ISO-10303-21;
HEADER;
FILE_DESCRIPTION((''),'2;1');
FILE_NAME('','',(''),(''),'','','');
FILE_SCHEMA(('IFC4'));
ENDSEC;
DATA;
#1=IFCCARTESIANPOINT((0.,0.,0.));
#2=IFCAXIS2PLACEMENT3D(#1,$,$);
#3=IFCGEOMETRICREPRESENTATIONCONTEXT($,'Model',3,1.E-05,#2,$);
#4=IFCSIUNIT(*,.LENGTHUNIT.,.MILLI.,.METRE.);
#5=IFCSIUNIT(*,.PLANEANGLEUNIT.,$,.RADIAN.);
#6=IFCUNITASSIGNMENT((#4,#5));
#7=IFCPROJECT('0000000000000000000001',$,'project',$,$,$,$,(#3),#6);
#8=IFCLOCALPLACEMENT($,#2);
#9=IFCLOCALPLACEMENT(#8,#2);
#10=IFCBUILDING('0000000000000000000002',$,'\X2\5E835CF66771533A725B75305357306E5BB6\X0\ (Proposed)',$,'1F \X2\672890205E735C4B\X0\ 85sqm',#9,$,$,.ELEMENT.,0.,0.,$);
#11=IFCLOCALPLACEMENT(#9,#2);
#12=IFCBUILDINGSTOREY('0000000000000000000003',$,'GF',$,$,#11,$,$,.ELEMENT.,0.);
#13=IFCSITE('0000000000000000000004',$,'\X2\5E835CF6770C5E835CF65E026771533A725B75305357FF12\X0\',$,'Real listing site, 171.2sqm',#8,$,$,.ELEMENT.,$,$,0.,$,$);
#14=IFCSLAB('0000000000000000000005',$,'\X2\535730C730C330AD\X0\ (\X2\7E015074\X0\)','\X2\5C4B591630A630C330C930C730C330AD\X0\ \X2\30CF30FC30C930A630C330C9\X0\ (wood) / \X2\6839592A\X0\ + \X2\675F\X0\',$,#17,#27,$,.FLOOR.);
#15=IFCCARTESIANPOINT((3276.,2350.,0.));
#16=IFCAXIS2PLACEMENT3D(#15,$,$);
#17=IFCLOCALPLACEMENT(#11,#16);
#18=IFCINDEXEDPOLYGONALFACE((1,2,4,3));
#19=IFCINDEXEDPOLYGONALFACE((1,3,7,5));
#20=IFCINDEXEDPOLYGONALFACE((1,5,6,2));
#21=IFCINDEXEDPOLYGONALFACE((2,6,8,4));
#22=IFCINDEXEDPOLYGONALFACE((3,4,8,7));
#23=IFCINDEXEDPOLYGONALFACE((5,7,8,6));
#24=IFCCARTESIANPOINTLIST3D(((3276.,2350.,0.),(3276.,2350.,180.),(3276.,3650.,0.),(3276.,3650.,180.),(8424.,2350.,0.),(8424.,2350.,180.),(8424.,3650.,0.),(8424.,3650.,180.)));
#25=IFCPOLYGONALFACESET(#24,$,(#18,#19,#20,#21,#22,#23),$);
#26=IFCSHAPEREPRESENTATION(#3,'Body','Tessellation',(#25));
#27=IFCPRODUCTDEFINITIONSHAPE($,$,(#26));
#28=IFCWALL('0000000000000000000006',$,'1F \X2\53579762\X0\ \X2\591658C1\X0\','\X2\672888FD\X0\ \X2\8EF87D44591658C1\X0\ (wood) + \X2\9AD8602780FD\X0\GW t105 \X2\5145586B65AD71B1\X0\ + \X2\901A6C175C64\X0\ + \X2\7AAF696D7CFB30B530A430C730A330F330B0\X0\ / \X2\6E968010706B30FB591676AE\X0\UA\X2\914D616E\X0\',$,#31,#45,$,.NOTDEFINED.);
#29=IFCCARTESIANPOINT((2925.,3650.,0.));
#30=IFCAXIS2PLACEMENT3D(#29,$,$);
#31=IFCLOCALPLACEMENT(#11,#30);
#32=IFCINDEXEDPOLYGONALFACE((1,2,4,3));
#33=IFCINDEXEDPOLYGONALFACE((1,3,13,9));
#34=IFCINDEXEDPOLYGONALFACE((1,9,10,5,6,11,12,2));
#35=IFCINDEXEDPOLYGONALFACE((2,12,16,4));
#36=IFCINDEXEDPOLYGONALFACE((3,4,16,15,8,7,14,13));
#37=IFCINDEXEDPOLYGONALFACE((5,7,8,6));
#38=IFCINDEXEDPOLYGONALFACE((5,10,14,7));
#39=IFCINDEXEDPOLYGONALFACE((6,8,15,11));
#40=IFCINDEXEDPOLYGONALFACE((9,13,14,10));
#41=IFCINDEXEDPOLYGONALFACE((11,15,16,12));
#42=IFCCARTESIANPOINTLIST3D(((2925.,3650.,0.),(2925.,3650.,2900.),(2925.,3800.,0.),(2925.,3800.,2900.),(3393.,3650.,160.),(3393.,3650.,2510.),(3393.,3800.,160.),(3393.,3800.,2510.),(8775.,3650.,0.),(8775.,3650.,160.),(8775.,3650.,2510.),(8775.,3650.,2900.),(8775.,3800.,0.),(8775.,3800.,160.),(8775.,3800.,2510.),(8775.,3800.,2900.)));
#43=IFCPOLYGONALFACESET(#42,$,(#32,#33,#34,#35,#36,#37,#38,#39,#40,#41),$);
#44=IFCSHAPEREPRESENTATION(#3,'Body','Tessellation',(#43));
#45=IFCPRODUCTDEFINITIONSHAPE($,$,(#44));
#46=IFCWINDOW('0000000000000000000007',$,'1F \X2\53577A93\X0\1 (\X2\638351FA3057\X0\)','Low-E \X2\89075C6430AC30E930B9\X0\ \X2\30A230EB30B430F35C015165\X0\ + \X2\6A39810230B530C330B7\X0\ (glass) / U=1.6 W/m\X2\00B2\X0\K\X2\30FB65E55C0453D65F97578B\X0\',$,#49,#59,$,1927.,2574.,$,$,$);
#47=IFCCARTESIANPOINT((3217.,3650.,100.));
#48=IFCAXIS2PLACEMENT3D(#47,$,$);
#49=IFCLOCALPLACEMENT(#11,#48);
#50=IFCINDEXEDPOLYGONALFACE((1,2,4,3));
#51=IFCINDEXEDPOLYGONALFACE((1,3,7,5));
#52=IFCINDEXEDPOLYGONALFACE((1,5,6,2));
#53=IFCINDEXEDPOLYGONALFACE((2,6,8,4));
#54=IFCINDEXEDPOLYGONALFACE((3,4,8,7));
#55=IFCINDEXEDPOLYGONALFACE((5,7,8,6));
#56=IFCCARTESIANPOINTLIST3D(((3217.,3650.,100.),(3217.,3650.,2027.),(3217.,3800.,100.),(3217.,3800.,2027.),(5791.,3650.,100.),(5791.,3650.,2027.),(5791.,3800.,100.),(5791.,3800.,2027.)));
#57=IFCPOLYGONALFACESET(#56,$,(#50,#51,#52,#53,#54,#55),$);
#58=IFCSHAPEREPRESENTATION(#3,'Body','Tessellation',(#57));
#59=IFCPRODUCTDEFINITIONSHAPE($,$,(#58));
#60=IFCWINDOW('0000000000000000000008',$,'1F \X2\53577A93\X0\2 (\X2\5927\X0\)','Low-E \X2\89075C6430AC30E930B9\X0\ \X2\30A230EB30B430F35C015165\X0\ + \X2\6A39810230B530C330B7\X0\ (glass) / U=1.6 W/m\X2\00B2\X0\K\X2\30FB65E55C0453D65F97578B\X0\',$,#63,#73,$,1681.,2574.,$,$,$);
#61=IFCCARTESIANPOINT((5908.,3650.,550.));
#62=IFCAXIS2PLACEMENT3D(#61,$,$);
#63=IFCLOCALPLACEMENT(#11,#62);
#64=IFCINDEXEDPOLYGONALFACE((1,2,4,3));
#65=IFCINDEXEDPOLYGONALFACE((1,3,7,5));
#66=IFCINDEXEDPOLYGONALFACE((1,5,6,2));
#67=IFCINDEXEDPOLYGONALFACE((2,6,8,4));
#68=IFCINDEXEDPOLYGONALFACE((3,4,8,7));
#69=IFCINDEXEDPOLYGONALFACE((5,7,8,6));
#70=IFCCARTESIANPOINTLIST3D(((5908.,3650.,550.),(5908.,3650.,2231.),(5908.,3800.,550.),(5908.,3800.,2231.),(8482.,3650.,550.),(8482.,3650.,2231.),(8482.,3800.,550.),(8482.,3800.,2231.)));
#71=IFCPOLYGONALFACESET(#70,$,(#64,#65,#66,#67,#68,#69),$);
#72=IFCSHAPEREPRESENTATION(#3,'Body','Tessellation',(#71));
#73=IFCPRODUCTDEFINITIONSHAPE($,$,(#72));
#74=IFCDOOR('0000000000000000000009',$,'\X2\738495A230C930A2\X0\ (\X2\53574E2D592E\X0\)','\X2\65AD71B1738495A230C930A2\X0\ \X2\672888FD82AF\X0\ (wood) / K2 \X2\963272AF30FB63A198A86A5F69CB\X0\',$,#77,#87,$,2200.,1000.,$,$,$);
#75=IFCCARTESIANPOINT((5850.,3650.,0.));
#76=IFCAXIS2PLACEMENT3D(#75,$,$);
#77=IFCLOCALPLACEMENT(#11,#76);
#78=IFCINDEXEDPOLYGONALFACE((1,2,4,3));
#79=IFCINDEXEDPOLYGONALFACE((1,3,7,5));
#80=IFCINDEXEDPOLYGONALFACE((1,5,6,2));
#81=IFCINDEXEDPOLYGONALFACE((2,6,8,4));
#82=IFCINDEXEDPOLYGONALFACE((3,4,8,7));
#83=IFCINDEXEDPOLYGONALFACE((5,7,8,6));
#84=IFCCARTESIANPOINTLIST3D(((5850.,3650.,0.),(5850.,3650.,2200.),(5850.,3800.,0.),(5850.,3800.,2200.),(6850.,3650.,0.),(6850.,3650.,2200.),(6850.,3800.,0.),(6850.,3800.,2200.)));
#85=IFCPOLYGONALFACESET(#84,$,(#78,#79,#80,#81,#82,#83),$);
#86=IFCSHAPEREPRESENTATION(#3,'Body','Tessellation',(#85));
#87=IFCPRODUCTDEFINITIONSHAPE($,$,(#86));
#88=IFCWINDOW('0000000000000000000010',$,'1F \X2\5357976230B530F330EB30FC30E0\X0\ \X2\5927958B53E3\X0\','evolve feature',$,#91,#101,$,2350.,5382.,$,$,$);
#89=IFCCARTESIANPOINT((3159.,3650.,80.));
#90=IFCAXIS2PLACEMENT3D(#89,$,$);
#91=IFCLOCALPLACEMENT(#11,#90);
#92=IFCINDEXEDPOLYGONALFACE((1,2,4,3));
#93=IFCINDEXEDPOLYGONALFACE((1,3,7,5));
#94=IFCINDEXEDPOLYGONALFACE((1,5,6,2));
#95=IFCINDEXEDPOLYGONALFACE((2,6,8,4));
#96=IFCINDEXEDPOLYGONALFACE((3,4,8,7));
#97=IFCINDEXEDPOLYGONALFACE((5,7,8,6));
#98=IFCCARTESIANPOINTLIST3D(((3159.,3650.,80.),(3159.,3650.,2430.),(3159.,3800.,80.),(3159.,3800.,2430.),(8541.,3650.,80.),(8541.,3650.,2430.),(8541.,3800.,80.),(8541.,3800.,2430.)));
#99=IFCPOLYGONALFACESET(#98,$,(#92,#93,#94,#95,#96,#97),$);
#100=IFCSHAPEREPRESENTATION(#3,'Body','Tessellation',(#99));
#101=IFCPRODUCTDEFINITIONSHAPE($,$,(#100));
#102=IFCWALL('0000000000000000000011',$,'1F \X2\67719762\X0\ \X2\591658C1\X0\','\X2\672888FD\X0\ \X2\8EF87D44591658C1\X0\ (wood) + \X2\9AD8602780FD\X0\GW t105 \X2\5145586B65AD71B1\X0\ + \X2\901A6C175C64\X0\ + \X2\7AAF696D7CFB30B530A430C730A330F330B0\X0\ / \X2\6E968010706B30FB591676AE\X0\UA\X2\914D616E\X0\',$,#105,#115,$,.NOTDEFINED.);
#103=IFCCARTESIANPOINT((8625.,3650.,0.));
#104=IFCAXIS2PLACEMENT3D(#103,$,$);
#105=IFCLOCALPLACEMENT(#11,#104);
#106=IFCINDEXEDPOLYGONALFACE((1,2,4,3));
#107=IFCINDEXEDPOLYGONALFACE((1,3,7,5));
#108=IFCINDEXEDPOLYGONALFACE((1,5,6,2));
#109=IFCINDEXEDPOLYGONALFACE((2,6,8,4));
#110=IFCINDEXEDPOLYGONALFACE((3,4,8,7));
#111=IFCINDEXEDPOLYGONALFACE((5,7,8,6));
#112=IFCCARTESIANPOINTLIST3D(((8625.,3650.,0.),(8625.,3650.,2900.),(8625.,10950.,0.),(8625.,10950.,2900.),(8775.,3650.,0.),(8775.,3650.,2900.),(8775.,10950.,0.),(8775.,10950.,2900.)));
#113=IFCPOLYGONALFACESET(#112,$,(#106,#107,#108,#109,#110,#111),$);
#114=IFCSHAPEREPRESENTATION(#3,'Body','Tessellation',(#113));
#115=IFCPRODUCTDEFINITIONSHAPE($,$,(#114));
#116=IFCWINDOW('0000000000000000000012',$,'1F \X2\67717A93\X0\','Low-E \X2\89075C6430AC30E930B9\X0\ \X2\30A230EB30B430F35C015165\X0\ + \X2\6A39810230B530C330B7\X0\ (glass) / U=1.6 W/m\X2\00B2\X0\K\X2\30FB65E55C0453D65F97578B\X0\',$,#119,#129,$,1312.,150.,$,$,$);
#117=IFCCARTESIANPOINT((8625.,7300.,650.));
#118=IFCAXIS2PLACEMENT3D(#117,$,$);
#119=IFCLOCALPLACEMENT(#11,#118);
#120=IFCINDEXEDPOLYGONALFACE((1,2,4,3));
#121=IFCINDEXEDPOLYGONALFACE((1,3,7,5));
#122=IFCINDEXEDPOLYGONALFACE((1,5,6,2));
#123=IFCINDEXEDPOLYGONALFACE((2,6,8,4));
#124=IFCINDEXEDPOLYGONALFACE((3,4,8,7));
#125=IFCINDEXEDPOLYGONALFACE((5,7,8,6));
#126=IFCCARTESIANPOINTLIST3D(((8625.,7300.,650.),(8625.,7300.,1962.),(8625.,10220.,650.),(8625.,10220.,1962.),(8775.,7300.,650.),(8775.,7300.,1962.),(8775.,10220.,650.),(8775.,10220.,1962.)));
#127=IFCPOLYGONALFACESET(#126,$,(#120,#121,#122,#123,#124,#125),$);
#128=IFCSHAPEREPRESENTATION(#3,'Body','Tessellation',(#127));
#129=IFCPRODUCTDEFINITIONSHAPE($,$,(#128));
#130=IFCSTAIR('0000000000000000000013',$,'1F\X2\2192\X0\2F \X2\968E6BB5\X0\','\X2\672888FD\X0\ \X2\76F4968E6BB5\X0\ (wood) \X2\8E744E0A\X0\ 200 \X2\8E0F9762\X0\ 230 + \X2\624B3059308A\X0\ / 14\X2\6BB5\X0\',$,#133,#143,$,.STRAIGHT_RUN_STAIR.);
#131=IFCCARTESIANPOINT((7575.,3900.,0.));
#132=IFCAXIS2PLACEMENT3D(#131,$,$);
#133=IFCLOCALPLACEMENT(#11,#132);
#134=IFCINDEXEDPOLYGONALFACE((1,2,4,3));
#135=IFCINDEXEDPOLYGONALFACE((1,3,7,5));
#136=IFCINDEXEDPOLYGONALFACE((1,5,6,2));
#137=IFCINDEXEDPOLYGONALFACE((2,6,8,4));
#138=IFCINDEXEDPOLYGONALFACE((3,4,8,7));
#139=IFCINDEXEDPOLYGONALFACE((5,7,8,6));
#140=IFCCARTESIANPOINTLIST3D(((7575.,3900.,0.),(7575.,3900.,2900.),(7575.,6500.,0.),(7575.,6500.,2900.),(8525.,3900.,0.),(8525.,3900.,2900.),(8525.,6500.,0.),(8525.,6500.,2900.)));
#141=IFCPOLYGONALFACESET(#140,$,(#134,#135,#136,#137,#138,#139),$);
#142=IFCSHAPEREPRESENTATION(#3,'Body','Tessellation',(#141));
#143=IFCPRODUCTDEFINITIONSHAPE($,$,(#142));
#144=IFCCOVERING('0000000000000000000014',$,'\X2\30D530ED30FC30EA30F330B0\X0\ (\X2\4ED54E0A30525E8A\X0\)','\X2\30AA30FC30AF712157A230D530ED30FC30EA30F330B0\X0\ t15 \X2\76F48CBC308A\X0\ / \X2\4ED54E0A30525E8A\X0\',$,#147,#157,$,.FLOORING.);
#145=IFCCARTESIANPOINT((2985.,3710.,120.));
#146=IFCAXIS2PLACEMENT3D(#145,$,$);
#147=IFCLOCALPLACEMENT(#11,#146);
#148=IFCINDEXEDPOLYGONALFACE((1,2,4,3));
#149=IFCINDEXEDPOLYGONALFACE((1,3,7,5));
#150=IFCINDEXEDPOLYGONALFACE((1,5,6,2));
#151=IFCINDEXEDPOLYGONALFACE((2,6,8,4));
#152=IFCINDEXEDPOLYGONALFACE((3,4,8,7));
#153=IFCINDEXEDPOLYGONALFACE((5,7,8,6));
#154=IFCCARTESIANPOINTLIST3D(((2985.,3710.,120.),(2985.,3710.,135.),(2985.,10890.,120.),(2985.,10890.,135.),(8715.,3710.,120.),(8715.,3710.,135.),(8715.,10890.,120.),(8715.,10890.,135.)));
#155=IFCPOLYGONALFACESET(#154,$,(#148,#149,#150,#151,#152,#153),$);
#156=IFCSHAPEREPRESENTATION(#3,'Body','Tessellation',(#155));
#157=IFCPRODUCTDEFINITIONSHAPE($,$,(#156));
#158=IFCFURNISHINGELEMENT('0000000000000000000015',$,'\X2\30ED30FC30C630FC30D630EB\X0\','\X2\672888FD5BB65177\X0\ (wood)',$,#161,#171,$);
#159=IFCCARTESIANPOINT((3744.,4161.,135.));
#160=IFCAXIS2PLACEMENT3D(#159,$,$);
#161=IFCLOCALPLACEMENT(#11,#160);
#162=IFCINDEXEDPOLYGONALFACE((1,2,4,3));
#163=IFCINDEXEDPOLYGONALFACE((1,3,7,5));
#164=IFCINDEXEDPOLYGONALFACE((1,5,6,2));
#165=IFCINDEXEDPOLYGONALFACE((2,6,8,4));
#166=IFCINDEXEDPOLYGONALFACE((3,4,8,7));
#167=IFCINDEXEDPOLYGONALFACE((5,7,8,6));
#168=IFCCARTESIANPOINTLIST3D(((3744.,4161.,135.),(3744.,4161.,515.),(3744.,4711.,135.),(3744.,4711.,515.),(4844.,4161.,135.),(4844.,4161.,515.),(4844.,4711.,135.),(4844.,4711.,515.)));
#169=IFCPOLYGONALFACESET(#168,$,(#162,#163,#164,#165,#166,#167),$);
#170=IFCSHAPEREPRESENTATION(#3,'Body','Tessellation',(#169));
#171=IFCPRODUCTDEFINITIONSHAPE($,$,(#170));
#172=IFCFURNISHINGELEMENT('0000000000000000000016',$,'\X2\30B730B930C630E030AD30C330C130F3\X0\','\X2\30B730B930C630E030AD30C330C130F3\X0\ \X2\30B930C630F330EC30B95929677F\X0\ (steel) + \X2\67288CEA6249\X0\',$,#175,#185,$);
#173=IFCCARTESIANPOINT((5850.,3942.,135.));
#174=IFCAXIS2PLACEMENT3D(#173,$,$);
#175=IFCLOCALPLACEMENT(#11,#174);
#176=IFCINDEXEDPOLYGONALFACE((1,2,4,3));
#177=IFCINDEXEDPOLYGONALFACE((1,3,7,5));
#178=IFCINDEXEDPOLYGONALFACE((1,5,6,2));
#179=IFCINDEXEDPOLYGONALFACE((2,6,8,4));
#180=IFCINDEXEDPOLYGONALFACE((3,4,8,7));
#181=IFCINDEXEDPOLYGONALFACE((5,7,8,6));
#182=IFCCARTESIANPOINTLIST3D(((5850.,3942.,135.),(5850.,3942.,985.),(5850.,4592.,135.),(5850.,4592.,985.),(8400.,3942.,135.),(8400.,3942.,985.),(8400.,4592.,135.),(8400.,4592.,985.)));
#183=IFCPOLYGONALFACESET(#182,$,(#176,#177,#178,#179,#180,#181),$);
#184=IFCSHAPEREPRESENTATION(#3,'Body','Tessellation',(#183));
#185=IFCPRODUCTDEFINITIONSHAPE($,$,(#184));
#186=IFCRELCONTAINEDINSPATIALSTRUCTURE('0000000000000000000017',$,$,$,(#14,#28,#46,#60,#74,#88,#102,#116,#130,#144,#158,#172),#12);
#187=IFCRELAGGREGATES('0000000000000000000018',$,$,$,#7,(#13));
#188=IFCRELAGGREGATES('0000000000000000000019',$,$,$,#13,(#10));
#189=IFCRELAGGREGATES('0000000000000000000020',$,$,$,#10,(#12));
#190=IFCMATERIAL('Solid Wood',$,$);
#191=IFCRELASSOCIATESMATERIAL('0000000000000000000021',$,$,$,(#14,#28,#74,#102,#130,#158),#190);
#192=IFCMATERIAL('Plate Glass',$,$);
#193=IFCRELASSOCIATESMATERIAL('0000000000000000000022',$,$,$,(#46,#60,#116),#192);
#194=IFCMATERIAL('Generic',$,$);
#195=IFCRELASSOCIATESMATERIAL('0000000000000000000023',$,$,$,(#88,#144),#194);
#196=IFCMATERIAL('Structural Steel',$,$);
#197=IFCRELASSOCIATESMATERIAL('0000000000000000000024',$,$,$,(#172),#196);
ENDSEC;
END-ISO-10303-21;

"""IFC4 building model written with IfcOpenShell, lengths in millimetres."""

from ifc_helpers import new_model, si_unit, frame, frame_2d, origin, place, context, project, spatial, rectangle, extrude, material, element, fill, save


model = new_model("IFC4")

# Units and contexts
model_context = context("Model", 3, precision=1e-05, world=origin())
ifc_project = project(units=[si_unit("LENGTHUNIT", "METRE", prefix="MILLI"), si_unit("PLANEANGLEUNIT", "RADIAN")], contexts=[model_context])

# Site, building, storey
site_placement = place(None, origin())
site = spatial("IfcSite", under=ifc_project, at=site_placement, Name="広島県広島市東区牛田南２", ObjectType="Real listing site, 171.2sqm", CompositionType="ELEMENT", RefElevation=0.0)
building_placement = place(site_placement, origin())
building = spatial("IfcBuilding", under=site, at=building_placement, Name="広島東区牛田南の家 (Proposed)", ObjectType="1F 木造平屋 85sqm", CompositionType="ELEMENT", ElevationOfRefHeight=0.0, ElevationOfTerrain=0.0)
storey_placement = place(building_placement, origin())
storey = spatial("IfcBuildingStorey", under=building, at=storey_placement, Name="GF", CompositionType="ELEMENT", Elevation=0.0)

# Slab
ifc_material_1 = material(Name="Solid Wood")
slab_1_placement = place(storey_placement, frame((3276.0, 2350.0, 0.0)))
element("IfcSlab", 1, at=slab_1_placement, inside=storey, material=ifc_material_1, Name="南デッキ (縁側)", Description="屋外ウッドデッキ ハードウッド (wood) / 根太 + 束", PredefinedType="FLOOR", context=model_context, shape_type="SweptSolid", body=[
    extrude(rectangle(XDim=5148.0, YDim=1300.0, at=frame_2d((2574.0, 650.0))), frame((3276.0, 2350.0, 0.0)), (0.0, 0.0, 1.0), 180.0),
])
ifc_material_2 = material(Name="Generic")

# Wall, openings, windows, door
wall_1_placement = place(storey_placement, frame((2925.0, 3650.0, 0.0)))
wall_1 = element("IfcWall", 2, at=wall_1_placement, inside=storey, material=ifc_material_1, Name="1F 南面 外壁", Description="木製 軸組外壁 (wood) + 高性能GW t105 充填断熱 + 通気層 + 窯業系サイディング / 準耐火・外皮UA配慮", PredefinedType="NOTDEFINED", context=model_context, shape_type="SweptSolid", body=[
    extrude(rectangle(XDim=5850.0, YDim=150.0, at=frame_2d((2925.0, 75.0))), frame((2925.0, 3650.0, 0.0)), (0.0, 0.0, 1.0), 2900.0),
])
opening_1_placement = place(storey_placement, frame((3217.0, 3650.0, 100.0)))
opening_1 = element("IfcOpeningElement", 3, at=opening_1_placement, cuts=wall_1, PredefinedType="NOTDEFINED", context=model_context, shape_type="SweptSolid", body=[
    extrude(rectangle(XDim=2574.0, YDim=150.0, at=frame_2d((1287.0, 75.0))), frame((3217.0, 3650.0, 100.0)), (0.0, 0.0, 1.0), 1927.0),
])
opening_2_placement = place(storey_placement, frame((5908.0, 3650.0, 550.0)))
opening_2 = element("IfcOpeningElement", 4, at=opening_2_placement, cuts=wall_1, PredefinedType="NOTDEFINED", context=model_context, shape_type="SweptSolid", body=[
    extrude(rectangle(XDim=2574.0, YDim=150.0, at=frame_2d((1287.0, 75.0))), frame((5908.0, 3650.0, 550.0)), (0.0, 0.0, 1.0), 1681.0),
])
opening_3_placement = place(storey_placement, frame((5850.0, 3650.0, 0.0)))
opening_3 = element("IfcOpeningElement", 5, at=opening_3_placement, cuts=wall_1, PredefinedType="NOTDEFINED", context=model_context, shape_type="SweptSolid", body=[
    extrude(rectangle(XDim=1000.0, YDim=150.0, at=frame_2d((500.0, 75.0))), frame((5850.0, 3650.0, 0.0)), (0.0, 0.0, 1.0), 2200.0),
])
opening_4_placement = place(storey_placement, frame((3159.0, 3650.0, 80.0)))
opening_4 = element("IfcOpeningElement", 6, at=opening_4_placement, cuts=wall_1, PredefinedType="NOTDEFINED", context=model_context, shape_type="SweptSolid", body=[
    extrude(rectangle(XDim=5382.0, YDim=150.0, at=frame_2d((2691.0, 75.0))), frame((3159.0, 3650.0, 80.0)), (0.0, 0.0, 1.0), 2350.0),
])
ifc_material_3 = material(Name="Plate Glass")
window_1_placement = place(storey_placement, frame((3217.0, 3650.0, 100.0)))
window_1 = element("IfcWindow", 7, at=window_1_placement, inside=storey, material=ifc_material_3, Name="1F 南窓1 (掃出し)", Description="Low-E 複層ガラス アルゴン封入 + 樹脂サッシ (glass) / U=1.6 W/m²K・日射取得型", OverallHeight=1927.0, OverallWidth=2574.0, context=model_context, shape_type="SweptSolid", body=[
    extrude(rectangle(XDim=2574.0, YDim=150.0, at=frame_2d((1287.0, 75.0))), frame((3217.0, 3650.0, 100.0)), (0.0, 0.0, 1.0), 1927.0),
])
fill(opening_1, window_1)
window_2_placement = place(storey_placement, frame((5908.0, 3650.0, 550.0)))
window_2 = element("IfcWindow", 8, at=window_2_placement, inside=storey, material=ifc_material_3, Name="1F 南窓2 (大)", Description="Low-E 複層ガラス アルゴン封入 + 樹脂サッシ (glass) / U=1.6 W/m²K・日射取得型", OverallHeight=1681.0, OverallWidth=2574.0, context=model_context, shape_type="SweptSolid", body=[
    extrude(rectangle(XDim=2574.0, YDim=150.0, at=frame_2d((1287.0, 75.0))), frame((5908.0, 3650.0, 550.0)), (0.0, 0.0, 1.0), 1681.0),
])
fill(opening_2, window_2)
door_placement = place(storey_placement, frame((5850.0, 3650.0, 0.0)))
door = element("IfcDoor", 9, at=door_placement, inside=storey, material=ifc_material_1, Name="玄関ドア (南中央)", Description="断熱玄関ドア 木製芯 (wood) / K2 防犯・採風機構", OverallHeight=2200.0, OverallWidth=1000.0, context=model_context, shape_type="SweptSolid", body=[
    extrude(rectangle(XDim=1000.0, YDim=150.0, at=frame_2d((500.0, 75.0))), frame((5850.0, 3650.0, 0.0)), (0.0, 0.0, 1.0), 2200.0),
])
fill(opening_3, door)
window_3_placement = place(storey_placement, frame((3159.0, 3650.0, 80.0)))
window_3 = element("IfcWindow", 10, at=window_3_placement, inside=storey, material=ifc_material_2, Name="1F 南面サンルーム 大開口", Description="evolve feature", OverallHeight=2350.0, OverallWidth=5382.0, context=model_context, shape_type="SweptSolid", body=[
    extrude(rectangle(XDim=5382.0, YDim=150.0, at=frame_2d((2691.0, 75.0))), frame((3159.0, 3650.0, 80.0)), (0.0, 0.0, 1.0), 2350.0),
])
fill(opening_4, window_3)

# Wall, opening, window
wall_2_placement = place(storey_placement, frame((8625.0, 3650.0, 0.0)))
wall_2 = element("IfcWall", 11, at=wall_2_placement, inside=storey, material=ifc_material_1, Name="1F 東面 外壁", Description="木製 軸組外壁 (wood) + 高性能GW t105 充填断熱 + 通気層 + 窯業系サイディング / 準耐火・外皮UA配慮", PredefinedType="NOTDEFINED", context=model_context, shape_type="SweptSolid", body=[
    extrude(rectangle(XDim=150.0, YDim=7300.0, at=frame_2d((75.0, 3650.0))), frame((8625.0, 3650.0, 0.0)), (0.0, 0.0, 1.0), 2900.0),
])
opening_5_placement = place(storey_placement, frame((8625.0, 7300.0, 650.0)))
opening_5 = element("IfcOpeningElement", 12, at=opening_5_placement, cuts=wall_2, PredefinedType="NOTDEFINED", context=model_context, shape_type="SweptSolid", body=[
    extrude(rectangle(XDim=150.0, YDim=2920.0, at=frame_2d((75.0, 1460.0))), frame((8625.0, 7300.0, 650.0)), (0.0, 0.0, 1.0), 1312.0),
])
window_4_placement = place(storey_placement, frame((8625.0, 7300.0, 650.0)))
window_4 = element("IfcWindow", 13, at=window_4_placement, inside=storey, material=ifc_material_3, Name="1F 東窓", Description="Low-E 複層ガラス アルゴン封入 + 樹脂サッシ (glass) / U=1.6 W/m²K・日射取得型", OverallHeight=1312.0, OverallWidth=150.0, context=model_context, shape_type="SweptSolid", body=[
    extrude(rectangle(XDim=150.0, YDim=2920.0, at=frame_2d((75.0, 1460.0))), frame((8625.0, 7300.0, 650.0)), (0.0, 0.0, 1.0), 1312.0),
])
fill(opening_5, window_4)

# Stair
stair_placement = place(storey_placement, frame((7575.0, 3900.0, 0.0)))
element("IfcStair", 14, at=stair_placement, inside=storey, material=ifc_material_1, Name="1F→2F 階段", Description="木製 直階段 (wood) 蹴上 200 踏面 230 + 手すり / 14段", PredefinedType="STRAIGHT_RUN_STAIR", context=model_context, shape_type="SweptSolid", body=[
    extrude(rectangle(XDim=950.0, YDim=2600.0, at=frame_2d((475.0, 1300.0))), frame((7575.0, 3900.0, 0.0)), (0.0, 0.0, 1.0), 2900.0),
])

# Covering
covering_placement = place(storey_placement, frame((2985.0, 3710.0, 120.0)))
element("IfcCovering", 15, at=covering_placement, inside=storey, material=ifc_material_2, Name="フローリング (仕上げ床)", Description="オーク無垢フローリング t15 直貼り / 仕上げ床", PredefinedType="FLOORING", context=model_context, shape_type="SweptSolid", body=[
    extrude(rectangle(XDim=5730.0, YDim=7180.0, at=frame_2d((2865.0, 3590.0))), frame((2985.0, 3710.0, 120.0)), (0.0, 0.0, 1.0), 15.0),
])

# Furnishing elements
furnishing_1_placement = place(storey_placement, frame((3744.0, 4161.0, 135.0)))
element("IfcFurnishingElement", 16, at=furnishing_1_placement, inside=storey, material=ifc_material_1, Name="ローテーブル", Description="木製家具 (wood)", context=model_context, shape_type="SweptSolid", body=[
    extrude(rectangle(XDim=1100.0, YDim=550.0, at=frame_2d((550.0, 275.0))), frame((3744.0, 4161.0, 135.0)), (0.0, 0.0, 1.0), 380.0),
])
ifc_material_4 = material(Name="Structural Steel")
furnishing_2_placement = place(storey_placement, frame((5850.0, 3942.0, 135.0)))
element("IfcFurnishingElement", 17, at=furnishing_2_placement, inside=storey, material=ifc_material_4, Name="システムキッチン", Description="システムキッチン ステンレス天板 (steel) + 木質扉", context=model_context, shape_type="SweptSolid", body=[
    extrude(rectangle(XDim=2550.0, YDim=650.0, at=frame_2d((1275.0, 325.0))), frame((5850.0, 3942.0, 135.0)), (0.0, 0.0, 1.0), 850.0),
])

save(model, "model.ifc")
